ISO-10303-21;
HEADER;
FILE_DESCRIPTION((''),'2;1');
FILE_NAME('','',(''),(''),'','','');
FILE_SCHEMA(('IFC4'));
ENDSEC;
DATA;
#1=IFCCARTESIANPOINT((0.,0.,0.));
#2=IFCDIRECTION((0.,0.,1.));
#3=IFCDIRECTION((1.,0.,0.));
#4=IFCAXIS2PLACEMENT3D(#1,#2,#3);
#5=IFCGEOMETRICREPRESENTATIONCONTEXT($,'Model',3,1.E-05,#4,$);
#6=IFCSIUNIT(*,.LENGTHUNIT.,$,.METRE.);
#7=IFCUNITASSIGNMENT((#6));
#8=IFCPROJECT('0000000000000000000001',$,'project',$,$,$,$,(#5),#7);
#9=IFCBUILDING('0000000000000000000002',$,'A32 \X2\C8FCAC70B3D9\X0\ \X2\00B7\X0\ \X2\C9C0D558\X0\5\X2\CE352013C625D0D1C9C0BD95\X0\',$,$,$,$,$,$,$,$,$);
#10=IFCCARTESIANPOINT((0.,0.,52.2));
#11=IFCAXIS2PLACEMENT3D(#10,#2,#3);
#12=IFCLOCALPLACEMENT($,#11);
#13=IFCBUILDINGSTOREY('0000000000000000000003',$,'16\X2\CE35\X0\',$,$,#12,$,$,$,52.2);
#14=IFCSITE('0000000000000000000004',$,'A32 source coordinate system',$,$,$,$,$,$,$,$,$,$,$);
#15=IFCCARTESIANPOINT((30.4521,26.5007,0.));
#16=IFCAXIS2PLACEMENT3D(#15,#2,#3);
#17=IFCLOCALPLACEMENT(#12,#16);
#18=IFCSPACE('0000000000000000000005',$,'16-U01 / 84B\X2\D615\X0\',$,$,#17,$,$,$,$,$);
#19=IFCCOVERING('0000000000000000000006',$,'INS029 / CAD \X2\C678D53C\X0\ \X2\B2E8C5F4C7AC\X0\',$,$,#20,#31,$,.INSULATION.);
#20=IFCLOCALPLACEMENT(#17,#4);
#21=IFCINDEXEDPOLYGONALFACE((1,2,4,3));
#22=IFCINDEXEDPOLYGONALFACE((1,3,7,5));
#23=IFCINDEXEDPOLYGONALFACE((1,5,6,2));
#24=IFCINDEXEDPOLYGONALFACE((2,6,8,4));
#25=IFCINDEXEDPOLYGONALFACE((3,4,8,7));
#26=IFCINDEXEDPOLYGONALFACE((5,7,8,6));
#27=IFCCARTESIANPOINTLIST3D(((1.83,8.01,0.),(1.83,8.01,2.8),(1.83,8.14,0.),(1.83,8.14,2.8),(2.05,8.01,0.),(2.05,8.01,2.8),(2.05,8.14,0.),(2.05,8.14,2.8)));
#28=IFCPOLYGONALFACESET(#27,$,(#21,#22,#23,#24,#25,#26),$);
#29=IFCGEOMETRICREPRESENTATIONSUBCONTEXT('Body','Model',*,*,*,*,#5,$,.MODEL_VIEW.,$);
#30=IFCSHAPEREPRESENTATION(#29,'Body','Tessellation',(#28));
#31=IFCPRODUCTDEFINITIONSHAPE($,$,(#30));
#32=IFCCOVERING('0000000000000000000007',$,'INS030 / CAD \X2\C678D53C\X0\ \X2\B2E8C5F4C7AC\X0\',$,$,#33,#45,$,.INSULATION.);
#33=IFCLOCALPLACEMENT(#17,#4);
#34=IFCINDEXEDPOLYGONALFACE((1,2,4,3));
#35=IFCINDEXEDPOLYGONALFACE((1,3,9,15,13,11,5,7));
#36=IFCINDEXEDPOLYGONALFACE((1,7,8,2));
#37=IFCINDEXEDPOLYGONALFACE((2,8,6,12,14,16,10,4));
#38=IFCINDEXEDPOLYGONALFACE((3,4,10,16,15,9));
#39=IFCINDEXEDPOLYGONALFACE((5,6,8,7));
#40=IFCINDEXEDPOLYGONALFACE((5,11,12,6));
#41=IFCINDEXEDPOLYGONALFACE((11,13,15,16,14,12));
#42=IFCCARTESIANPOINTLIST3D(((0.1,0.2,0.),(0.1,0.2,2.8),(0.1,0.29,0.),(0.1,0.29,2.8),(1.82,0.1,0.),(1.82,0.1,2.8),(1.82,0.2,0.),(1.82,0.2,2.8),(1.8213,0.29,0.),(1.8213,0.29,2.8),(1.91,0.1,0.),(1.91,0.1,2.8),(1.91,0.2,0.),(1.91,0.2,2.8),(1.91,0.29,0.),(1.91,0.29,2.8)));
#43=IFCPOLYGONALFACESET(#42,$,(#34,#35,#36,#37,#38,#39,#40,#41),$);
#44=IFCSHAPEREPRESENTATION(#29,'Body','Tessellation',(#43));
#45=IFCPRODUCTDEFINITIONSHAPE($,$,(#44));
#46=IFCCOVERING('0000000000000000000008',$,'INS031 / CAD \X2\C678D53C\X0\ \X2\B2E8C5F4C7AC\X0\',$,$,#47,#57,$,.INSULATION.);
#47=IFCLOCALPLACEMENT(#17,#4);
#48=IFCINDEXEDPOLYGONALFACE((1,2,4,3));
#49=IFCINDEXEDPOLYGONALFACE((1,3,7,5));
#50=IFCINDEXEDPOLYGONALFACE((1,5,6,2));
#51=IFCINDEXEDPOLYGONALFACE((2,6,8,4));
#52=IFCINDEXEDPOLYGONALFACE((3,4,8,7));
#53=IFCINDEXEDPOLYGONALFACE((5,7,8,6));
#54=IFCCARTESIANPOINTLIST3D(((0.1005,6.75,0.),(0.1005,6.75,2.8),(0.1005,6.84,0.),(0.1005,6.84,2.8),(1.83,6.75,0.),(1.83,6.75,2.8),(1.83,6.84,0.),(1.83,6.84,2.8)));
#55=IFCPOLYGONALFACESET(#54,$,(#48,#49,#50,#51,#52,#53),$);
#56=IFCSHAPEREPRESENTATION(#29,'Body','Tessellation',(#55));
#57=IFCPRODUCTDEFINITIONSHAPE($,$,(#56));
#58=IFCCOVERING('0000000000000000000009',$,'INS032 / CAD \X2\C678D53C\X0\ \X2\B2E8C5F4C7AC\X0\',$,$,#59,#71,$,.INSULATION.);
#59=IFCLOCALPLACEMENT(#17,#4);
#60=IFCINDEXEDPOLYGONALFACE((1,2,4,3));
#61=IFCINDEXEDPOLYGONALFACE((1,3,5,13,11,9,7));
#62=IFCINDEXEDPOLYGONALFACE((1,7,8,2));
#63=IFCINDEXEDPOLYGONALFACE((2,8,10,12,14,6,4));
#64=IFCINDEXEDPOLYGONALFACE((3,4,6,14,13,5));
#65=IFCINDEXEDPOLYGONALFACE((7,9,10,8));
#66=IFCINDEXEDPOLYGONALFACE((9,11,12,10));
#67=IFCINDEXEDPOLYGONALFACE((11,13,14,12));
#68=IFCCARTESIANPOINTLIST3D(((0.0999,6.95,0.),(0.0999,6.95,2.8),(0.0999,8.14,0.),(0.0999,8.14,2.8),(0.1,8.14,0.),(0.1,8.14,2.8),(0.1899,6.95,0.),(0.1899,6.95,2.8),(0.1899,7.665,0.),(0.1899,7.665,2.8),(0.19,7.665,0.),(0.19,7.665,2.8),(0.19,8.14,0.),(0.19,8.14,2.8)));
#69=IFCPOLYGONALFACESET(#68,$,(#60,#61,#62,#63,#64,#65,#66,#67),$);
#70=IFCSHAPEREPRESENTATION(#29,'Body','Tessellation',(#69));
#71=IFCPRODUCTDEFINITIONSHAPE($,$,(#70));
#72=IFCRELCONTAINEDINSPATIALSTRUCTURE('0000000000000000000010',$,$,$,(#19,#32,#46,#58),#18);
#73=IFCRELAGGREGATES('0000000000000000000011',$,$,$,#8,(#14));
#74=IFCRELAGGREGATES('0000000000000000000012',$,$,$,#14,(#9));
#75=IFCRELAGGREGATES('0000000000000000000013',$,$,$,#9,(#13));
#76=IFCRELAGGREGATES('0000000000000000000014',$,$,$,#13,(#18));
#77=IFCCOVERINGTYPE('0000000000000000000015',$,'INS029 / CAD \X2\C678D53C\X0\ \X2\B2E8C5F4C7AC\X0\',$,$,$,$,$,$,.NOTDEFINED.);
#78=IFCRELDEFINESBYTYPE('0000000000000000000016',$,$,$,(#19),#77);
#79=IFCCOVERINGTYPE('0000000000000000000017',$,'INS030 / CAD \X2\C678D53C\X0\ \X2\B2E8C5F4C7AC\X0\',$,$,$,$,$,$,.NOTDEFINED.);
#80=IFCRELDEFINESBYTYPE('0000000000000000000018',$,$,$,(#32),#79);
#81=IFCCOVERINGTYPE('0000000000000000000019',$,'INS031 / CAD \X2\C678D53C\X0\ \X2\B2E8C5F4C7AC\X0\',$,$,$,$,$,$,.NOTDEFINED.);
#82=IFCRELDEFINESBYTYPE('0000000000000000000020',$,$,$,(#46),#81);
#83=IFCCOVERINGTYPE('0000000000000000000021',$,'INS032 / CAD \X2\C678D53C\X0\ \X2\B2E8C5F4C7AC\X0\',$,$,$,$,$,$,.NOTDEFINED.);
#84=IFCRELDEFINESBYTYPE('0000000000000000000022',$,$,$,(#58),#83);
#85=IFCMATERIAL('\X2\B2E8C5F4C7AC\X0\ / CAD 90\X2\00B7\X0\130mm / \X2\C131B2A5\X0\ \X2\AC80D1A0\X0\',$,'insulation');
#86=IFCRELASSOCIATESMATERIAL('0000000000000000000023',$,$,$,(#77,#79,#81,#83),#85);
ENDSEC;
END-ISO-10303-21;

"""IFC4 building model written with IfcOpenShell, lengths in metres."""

from ifc_helpers import new_model, si_unit, frame, origin, origin_with_axes, place, context, subcontext, project, spatial, polyline, outline, extrude, source, transform, mapped, material, type_object, type_shapes, element, save


model = new_model("IFC4")

# Units and contexts
model_context = context("Model", 3, precision=1e-05, world=origin_with_axes())
body_context = subcontext(model_context, "Body", "Model", "MODEL_VIEW")
ifc_project = project(units=[si_unit("LENGTHUNIT", "METRE")], contexts=[model_context])

# Site, building, storey, space
storey_placement = place(None, frame((0.0, 0.0, 52.2), z_axis=(0.0, 0.0, 1.0), x_axis=(1.0, 0.0, 0.0)))
space_placement = place(storey_placement, frame((30.4521, 26.5007, 0.0), z_axis=(0.0, 0.0, 1.0), x_axis=(1.0, 0.0, 0.0)))
site = spatial("IfcSite", under=ifc_project, Name="A32 source coordinate system")
building = spatial("IfcBuilding", under=site, Name="A32 주거동 · 지하5층–옥탑지붕")
storey = spatial("IfcBuildingStorey", under=building, at=storey_placement, Name="16층", Elevation=52.2)
space = spatial("IfcSpace", under=storey, at=space_placement, Name="16-U01 / 84B형")

# Coverings
ifc_material = material(Name="단열재 / CAD 90·130mm / 성능 검토", Category="insulation")
covering_type_1 = type_object("IfcCoveringType", Name="INS029 / CAD 외피 단열재", PredefinedType="NOTDEFINED", material=ifc_material)
shared_shape_1 = source(origin(), body_context, "Body", "SweptSolid", [
    extrude(outline(polyline([(1.83, 8.01), (1.83, 8.14), (2.05, 8.14), (2.05, 8.01), (1.83, 8.01)])), origin(), (0.0, 0.0, 1.0), 2.8),
])
type_shapes(covering_type_1, [shared_shape_1])
covering_1_placement = place(space_placement, origin_with_axes())
element("IfcCovering", 1, at=covering_1_placement, inside=space, type_object=covering_type_1, Name="INS029 / CAD 외피 단열재", PredefinedType="INSULATION", context=body_context, shape_type="MappedRepresentation", body=[
    mapped(shared_shape_1, transform((0.0, 0.0, 0.0), scale=1.0)),
])
covering_type_2 = type_object("IfcCoveringType", Name="INS030 / CAD 외피 단열재", PredefinedType="NOTDEFINED", material=ifc_material)
shared_shape_2 = source(origin(), body_context, "Body", "SweptSolid", [
    extrude(outline(polyline([(1.91, 0.2), (1.91, 0.1), (1.82, 0.1), (1.82, 0.2), (0.1, 0.2), (0.1, 0.29), (1.8213, 0.29), (1.91, 0.29), (1.91, 0.2)])), origin(), (0.0, 0.0, 1.0), 2.8),
])
type_shapes(covering_type_2, [shared_shape_2])
covering_2_placement = place(space_placement, origin_with_axes())
element("IfcCovering", 2, at=covering_2_placement, inside=space, type_object=covering_type_2, Name="INS030 / CAD 외피 단열재", PredefinedType="INSULATION", context=body_context, shape_type="MappedRepresentation", body=[
    mapped(shared_shape_2, transform((0.0, 0.0, 0.0), scale=1.0)),
])
covering_type_3 = type_object("IfcCoveringType", Name="INS031 / CAD 외피 단열재", PredefinedType="NOTDEFINED", material=ifc_material)
shared_shape_3 = source(origin(), body_context, "Body", "SweptSolid", [
    extrude(outline(polyline([(1.83, 6.75), (0.1005, 6.75), (0.1005, 6.84), (1.83, 6.84), (1.83, 6.75)])), origin(), (0.0, 0.0, 1.0), 2.8),
])
type_shapes(covering_type_3, [shared_shape_3])
covering_3_placement = place(space_placement, origin_with_axes())
element("IfcCovering", 3, at=covering_3_placement, inside=space, type_object=covering_type_3, Name="INS031 / CAD 외피 단열재", PredefinedType="INSULATION", context=body_context, shape_type="MappedRepresentation", body=[
    mapped(shared_shape_3, transform((0.0, 0.0, 0.0), scale=1.0)),
])
covering_type_4 = type_object("IfcCoveringType", Name="INS032 / CAD 외피 단열재", PredefinedType="NOTDEFINED", material=ifc_material)
shared_shape_4 = source(origin(), body_context, "Body", "SweptSolid", [
    extrude(outline(polyline([(0.1899, 6.95), (0.0999, 6.95), (0.0999, 8.14), (0.1, 8.14), (0.19, 8.14), (0.19, 7.665), (0.1899, 7.665), (0.1899, 6.95)])), origin(), (0.0, 0.0, 1.0), 2.8),
])
type_shapes(covering_type_4, [shared_shape_4])
covering_4_placement = place(space_placement, origin_with_axes())
element("IfcCovering", 4, at=covering_4_placement, inside=space, type_object=covering_type_4, Name="INS032 / CAD 외피 단열재", PredefinedType="INSULATION", context=body_context, shape_type="MappedRepresentation", body=[
    mapped(shared_shape_4, transform((0.0, 0.0, 0.0), scale=1.0)),
])

save(model, "model.ifc")
